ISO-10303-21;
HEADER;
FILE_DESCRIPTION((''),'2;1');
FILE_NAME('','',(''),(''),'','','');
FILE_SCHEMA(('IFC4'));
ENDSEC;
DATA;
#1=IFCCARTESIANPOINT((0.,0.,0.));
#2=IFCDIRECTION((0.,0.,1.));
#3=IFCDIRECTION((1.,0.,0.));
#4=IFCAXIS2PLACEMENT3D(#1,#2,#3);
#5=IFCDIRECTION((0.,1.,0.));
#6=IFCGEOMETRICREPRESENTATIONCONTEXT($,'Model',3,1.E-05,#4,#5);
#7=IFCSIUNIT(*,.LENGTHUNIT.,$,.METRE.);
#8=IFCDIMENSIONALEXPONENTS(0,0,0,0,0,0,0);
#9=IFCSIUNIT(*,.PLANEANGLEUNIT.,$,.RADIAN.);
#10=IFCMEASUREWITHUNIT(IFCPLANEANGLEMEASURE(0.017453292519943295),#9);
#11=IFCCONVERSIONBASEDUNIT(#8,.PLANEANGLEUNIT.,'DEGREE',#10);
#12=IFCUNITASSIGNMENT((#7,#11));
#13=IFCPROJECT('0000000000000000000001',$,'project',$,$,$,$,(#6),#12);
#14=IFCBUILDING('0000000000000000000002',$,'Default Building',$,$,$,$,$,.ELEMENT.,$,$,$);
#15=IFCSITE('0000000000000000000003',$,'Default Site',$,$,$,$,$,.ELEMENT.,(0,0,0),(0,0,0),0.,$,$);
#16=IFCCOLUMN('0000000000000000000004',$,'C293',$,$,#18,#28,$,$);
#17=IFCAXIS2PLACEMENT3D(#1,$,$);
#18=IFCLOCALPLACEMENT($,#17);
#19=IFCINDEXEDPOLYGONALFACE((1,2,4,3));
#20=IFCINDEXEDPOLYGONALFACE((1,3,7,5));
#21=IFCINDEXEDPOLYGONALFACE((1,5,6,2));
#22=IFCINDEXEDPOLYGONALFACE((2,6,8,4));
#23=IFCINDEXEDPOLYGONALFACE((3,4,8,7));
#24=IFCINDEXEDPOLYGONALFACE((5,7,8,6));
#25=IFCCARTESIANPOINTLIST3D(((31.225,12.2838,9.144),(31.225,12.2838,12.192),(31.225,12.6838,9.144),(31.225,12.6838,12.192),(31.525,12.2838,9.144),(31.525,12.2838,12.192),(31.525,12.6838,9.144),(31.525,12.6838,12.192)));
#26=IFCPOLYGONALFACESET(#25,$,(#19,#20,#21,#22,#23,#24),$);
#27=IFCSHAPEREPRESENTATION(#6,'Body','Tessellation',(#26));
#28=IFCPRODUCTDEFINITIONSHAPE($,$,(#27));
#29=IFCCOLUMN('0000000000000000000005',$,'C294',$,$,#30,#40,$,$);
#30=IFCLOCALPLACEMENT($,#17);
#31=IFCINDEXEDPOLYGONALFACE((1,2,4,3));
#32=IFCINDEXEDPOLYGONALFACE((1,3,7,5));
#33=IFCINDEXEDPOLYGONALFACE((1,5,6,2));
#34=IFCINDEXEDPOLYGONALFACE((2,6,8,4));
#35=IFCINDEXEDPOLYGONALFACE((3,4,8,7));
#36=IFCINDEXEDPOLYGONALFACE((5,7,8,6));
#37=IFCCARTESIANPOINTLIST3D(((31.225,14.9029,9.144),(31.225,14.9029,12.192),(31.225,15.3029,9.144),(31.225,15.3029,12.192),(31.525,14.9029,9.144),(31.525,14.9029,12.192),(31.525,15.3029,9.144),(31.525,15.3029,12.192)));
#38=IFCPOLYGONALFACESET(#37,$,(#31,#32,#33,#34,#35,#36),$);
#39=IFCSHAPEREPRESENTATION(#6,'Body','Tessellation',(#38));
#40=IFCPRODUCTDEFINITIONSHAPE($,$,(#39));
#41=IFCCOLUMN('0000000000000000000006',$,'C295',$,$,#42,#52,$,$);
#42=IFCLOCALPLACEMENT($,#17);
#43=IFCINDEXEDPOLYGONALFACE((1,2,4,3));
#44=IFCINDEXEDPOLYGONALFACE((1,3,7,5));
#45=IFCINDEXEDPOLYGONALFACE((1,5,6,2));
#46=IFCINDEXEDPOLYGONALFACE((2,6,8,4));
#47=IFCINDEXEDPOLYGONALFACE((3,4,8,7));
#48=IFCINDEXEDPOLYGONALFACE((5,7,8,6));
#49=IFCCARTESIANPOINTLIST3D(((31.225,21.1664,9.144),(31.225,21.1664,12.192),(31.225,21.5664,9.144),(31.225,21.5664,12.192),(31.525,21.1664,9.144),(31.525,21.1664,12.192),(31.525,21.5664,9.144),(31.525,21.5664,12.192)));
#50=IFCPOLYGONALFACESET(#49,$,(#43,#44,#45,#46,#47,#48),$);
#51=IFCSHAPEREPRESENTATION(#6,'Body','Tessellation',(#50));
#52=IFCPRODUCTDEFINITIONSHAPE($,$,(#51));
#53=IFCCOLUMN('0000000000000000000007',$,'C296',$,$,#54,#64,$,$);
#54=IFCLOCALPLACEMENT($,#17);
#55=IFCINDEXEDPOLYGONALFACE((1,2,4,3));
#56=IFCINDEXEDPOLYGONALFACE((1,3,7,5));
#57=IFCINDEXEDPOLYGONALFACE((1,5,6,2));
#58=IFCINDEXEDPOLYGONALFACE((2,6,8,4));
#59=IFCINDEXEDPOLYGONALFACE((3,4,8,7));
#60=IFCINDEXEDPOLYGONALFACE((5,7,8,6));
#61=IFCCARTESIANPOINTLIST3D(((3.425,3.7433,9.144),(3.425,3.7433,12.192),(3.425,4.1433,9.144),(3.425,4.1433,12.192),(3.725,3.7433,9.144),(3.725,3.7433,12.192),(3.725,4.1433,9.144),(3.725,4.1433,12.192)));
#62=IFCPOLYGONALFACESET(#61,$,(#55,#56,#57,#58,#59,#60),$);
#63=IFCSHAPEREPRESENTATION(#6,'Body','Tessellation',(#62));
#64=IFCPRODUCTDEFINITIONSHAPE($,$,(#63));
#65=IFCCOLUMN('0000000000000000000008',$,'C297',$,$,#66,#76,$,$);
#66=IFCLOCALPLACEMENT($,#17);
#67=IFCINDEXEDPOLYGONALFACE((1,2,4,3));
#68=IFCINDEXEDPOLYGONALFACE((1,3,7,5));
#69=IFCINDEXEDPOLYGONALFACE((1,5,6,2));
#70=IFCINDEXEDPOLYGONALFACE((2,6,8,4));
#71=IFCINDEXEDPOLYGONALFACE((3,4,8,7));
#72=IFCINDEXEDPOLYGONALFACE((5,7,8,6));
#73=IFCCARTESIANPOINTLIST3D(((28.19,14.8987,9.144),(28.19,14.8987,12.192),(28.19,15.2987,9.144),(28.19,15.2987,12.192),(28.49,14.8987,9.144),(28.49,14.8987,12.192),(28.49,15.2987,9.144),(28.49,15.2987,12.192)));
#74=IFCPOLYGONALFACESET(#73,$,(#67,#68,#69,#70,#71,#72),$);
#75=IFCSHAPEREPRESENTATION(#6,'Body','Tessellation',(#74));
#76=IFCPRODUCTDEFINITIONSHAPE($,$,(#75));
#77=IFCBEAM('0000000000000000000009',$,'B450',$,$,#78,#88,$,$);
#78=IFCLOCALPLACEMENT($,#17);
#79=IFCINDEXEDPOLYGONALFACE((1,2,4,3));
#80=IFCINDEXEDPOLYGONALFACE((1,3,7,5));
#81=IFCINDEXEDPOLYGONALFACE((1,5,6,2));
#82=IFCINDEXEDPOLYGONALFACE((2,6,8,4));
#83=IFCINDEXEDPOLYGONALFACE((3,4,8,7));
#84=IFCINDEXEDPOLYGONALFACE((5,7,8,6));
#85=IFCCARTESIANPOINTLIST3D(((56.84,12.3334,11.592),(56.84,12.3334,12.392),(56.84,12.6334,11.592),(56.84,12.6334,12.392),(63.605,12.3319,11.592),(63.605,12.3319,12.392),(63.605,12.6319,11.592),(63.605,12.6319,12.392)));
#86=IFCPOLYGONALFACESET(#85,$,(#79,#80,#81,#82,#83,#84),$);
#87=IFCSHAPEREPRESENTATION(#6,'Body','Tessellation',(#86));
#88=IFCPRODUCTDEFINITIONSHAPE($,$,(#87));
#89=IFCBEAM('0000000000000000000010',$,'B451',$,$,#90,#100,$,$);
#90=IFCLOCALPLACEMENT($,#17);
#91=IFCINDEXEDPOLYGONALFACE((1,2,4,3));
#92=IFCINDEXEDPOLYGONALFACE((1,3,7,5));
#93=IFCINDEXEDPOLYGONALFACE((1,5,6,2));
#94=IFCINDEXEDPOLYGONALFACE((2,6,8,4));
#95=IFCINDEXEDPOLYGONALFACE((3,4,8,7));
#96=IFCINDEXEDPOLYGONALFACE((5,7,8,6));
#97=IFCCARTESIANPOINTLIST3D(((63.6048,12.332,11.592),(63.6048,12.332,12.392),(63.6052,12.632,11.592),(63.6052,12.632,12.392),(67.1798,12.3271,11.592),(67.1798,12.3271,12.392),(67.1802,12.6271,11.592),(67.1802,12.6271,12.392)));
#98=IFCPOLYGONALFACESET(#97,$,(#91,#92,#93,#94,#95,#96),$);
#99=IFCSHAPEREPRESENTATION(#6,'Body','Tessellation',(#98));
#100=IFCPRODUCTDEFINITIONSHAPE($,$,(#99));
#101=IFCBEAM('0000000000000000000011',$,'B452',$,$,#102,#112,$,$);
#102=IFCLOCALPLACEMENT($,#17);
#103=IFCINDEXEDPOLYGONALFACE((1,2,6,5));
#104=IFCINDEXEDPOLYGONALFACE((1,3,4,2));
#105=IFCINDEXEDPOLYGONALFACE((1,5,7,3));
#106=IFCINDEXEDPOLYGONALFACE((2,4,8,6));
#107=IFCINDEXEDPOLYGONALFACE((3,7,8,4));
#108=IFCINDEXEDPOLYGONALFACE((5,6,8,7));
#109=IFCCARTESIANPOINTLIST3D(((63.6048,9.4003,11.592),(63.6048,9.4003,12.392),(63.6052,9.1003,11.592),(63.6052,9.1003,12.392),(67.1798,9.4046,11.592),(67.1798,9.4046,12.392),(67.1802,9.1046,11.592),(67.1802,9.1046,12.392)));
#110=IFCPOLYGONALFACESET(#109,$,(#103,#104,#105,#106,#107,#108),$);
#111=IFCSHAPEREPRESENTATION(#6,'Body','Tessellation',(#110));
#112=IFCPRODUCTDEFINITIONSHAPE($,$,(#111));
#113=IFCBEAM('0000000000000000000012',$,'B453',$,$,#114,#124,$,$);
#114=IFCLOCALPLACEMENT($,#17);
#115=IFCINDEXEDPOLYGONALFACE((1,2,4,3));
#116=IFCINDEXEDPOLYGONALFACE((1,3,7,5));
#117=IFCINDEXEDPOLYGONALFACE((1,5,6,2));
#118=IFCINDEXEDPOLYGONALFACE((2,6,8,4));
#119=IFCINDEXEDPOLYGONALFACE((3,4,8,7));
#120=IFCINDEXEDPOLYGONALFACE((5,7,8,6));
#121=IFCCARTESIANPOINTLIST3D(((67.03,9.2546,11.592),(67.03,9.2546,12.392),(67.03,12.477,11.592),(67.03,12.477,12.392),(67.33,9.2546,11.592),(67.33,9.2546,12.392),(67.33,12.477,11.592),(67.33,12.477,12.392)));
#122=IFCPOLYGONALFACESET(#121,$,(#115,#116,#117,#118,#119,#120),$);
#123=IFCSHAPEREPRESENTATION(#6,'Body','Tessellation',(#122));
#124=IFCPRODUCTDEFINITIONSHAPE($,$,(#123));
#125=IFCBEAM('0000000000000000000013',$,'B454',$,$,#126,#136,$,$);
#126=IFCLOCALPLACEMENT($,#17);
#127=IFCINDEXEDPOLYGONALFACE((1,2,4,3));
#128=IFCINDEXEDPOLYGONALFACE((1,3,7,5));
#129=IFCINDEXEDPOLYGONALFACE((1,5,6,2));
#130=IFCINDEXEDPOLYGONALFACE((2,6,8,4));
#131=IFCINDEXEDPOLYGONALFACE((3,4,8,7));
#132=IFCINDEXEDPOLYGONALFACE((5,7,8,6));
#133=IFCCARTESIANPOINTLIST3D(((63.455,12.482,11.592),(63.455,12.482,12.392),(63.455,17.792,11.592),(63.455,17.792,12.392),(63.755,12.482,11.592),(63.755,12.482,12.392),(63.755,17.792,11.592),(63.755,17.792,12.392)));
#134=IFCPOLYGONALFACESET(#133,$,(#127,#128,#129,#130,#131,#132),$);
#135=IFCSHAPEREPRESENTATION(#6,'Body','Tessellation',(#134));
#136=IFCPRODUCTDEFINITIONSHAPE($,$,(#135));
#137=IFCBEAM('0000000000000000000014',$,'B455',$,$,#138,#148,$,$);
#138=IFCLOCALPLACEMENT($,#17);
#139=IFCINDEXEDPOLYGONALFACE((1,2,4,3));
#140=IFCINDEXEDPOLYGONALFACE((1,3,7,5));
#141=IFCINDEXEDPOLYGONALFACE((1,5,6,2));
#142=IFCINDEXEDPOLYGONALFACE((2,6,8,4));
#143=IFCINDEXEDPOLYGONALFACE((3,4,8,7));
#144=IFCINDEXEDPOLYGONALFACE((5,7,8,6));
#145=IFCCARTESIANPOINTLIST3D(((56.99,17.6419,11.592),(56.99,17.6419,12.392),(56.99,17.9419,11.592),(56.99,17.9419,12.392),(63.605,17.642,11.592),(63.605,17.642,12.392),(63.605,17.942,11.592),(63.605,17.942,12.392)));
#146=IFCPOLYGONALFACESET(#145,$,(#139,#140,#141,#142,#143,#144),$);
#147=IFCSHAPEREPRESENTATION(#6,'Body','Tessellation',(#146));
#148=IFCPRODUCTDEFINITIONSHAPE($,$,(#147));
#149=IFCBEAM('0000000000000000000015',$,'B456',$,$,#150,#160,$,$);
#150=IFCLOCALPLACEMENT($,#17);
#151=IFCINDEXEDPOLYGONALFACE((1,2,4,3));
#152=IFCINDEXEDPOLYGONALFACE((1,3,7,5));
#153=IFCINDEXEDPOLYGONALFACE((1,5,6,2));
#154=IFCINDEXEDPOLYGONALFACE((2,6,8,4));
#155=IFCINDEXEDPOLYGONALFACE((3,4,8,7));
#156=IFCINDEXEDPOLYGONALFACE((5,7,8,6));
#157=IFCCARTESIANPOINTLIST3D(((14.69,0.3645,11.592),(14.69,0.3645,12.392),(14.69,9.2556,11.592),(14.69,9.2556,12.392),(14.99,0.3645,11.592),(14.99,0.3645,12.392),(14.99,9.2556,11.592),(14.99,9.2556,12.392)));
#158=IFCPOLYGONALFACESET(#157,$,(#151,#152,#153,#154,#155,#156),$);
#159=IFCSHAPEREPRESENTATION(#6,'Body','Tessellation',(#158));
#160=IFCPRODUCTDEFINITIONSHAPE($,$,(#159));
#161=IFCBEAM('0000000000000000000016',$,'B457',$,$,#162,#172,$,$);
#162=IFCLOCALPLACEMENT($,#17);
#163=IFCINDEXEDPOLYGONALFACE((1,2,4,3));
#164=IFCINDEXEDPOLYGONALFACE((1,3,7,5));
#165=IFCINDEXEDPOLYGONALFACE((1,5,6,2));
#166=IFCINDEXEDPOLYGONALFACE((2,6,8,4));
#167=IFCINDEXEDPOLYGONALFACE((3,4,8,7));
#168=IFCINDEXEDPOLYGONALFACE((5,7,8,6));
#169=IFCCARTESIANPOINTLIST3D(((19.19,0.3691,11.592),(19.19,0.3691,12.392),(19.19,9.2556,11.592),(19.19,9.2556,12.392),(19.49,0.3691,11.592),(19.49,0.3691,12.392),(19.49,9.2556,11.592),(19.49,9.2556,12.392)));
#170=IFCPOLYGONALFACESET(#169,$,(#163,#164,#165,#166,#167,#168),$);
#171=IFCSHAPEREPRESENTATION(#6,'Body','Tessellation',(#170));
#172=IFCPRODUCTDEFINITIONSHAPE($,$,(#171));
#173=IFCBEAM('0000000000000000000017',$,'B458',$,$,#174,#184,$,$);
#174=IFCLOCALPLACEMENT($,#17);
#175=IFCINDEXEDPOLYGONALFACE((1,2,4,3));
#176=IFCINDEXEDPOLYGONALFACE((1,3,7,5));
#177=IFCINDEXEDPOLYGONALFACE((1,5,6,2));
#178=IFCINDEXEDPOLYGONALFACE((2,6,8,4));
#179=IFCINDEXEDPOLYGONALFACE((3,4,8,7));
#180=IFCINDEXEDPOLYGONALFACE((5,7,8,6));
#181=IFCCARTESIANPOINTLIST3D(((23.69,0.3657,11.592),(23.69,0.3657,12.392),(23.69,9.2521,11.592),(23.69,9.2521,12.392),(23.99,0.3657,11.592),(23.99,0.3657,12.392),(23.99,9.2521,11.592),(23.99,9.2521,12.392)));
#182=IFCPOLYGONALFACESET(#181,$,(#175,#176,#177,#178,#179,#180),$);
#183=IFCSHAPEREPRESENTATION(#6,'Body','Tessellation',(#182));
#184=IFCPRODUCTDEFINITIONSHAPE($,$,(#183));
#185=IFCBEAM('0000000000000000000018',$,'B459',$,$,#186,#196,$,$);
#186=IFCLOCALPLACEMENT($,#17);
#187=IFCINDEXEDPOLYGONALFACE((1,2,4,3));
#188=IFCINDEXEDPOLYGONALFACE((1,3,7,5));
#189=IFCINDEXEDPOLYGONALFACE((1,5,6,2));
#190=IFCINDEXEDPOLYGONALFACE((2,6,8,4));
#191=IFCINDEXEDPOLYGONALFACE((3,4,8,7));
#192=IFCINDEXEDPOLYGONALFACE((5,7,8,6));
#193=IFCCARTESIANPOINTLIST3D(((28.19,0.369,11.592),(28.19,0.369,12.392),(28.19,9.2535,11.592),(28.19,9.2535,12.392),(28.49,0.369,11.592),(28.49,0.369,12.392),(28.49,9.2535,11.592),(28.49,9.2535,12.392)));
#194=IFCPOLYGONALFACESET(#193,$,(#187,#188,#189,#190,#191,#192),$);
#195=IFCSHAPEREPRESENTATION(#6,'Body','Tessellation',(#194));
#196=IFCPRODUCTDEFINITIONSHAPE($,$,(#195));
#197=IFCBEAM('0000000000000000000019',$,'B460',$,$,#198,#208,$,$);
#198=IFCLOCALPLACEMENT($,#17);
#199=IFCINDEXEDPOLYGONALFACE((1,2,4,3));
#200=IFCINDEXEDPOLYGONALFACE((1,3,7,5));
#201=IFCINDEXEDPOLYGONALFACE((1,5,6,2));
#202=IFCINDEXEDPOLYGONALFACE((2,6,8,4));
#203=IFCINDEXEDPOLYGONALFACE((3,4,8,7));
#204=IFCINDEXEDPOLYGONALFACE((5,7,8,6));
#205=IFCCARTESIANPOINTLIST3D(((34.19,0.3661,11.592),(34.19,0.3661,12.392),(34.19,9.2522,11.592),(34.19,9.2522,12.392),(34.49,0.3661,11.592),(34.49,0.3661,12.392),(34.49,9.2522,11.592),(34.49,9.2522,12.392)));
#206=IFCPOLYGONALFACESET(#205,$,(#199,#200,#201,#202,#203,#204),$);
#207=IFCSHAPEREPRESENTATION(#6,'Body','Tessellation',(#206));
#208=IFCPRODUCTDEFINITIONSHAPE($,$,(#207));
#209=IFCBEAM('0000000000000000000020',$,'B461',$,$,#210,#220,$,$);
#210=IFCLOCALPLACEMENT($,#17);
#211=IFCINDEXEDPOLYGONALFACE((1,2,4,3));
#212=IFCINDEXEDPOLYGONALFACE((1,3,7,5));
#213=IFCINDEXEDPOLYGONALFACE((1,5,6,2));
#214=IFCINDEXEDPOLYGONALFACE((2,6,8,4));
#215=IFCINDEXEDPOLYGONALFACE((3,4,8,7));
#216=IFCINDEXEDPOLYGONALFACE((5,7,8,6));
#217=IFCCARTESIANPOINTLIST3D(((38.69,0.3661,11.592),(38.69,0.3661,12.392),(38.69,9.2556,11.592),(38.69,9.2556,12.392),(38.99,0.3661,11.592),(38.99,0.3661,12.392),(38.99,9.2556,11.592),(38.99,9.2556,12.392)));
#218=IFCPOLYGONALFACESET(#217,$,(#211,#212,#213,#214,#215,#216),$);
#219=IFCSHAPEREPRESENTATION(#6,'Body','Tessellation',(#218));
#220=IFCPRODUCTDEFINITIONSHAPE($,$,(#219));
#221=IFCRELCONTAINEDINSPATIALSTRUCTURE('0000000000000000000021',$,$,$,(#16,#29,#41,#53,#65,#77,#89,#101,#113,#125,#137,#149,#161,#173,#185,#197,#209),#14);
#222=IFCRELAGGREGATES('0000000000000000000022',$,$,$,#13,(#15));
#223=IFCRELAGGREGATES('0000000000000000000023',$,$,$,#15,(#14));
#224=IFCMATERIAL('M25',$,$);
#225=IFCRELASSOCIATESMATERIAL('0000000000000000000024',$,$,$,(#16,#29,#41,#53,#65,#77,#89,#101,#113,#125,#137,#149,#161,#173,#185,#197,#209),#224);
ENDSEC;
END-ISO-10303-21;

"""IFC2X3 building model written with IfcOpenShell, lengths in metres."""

from ifc_helpers import new_model, entity, si_unit, converted_unit, direction, frame, frame_2d, origin_with_axes, place, context, project, spatial, rectangle, extrude, material, element, save


model = new_model("IFC2X3")

# Units and contexts
model_context = context("Model", 3, precision=1e-05, world=origin_with_axes(), true_north=direction((0.0, 1.0, 0.0)))
ifc_project = project(units=[si_unit("LENGTHUNIT", "METRE"), converted_unit("PLANEANGLEUNIT", "DEGREE", entity("IfcPlaneAngleMeasure", 0.017453292519943295), si_unit("PLANEANGLEUNIT", "RADIAN"), dimensions=[0, 0, 0, 0, 0, 0, 0])], contexts=[model_context])

# Site, building
site = spatial("IfcSite", under=ifc_project, Name="Default Site", CompositionType="ELEMENT", RefLatitude=(0, 0, 0), RefLongitude=(0, 0, 0), RefElevation=0.0)
building = spatial("IfcBuilding", under=site, Name="Default Building", CompositionType="ELEMENT")

# Columns
ifc_material = material(Name="M25")
placement = place(None, origin_with_axes())
element("IfcColumn", 1, at=placement, inside=building, material=ifc_material, Name="C293", context=model_context, shape_type="SweptSolid", body=[
    extrude(rectangle(XDim=0.3, YDim=0.4, at=frame_2d((0.0, 0.0), x_axis=(1.0, 0.0, 0.0))), frame((31.375, 12.4838, 9.144), z_axis=(0.0, 0.0, 1.0), x_axis=(1.0, 0.0, 0.0)), (0.0, 0.0, 1.0), 3.048),
])
element("IfcColumn", 2, at=placement, inside=building, material=ifc_material, Name="C294", context=model_context, shape_type="SweptSolid", body=[
    extrude(rectangle(XDim=0.3, YDim=0.4, at=frame_2d((0.0, 0.0), x_axis=(1.0, 0.0, 0.0))), frame((31.375, 15.1029, 9.144), z_axis=(0.0, 0.0, 1.0), x_axis=(1.0, 0.0, 0.0)), (0.0, 0.0, 1.0), 3.048),
])
element("IfcColumn", 3, at=placement, inside=building, material=ifc_material, Name="C295", context=model_context, shape_type="SweptSolid", body=[
    extrude(rectangle(XDim=0.3, YDim=0.4, at=frame_2d((0.0, 0.0), x_axis=(1.0, 0.0, 0.0))), frame((31.375, 21.3664, 9.144), z_axis=(0.0, 0.0, 1.0), x_axis=(1.0, 0.0, 0.0)), (0.0, 0.0, 1.0), 3.048),
])
element("IfcColumn", 4, at=placement, inside=building, material=ifc_material, Name="C296", context=model_context, shape_type="SweptSolid", body=[
    extrude(rectangle(XDim=0.3, YDim=0.4, at=frame_2d((0.0, 0.0), x_axis=(1.0, 0.0, 0.0))), frame((3.575, 3.9433, 9.144), z_axis=(0.0, 0.0, 1.0), x_axis=(1.0, 0.0, 0.0)), (0.0, 0.0, 1.0), 3.048),
])
element("IfcColumn", 5, at=placement, inside=building, material=ifc_material, Name="C297", context=model_context, shape_type="SweptSolid", body=[
    extrude(rectangle(XDim=0.3, YDim=0.4, at=frame_2d((0.0, 0.0), x_axis=(1.0, 0.0, 0.0))), frame((28.34, 15.0987, 9.144), z_axis=(0.0, 0.0, 1.0), x_axis=(1.0, 0.0, 0.0)), (0.0, 0.0, 1.0), 3.048),
])

# Beams
element("IfcBeam", 6, at=placement, inside=building, material=ifc_material, Name="B450", context=model_context, shape_type="SweptSolid", body=[
    extrude(rectangle(XDim=0.3, YDim=0.8, at=frame_2d((0.0, 0.0), x_axis=(0.0, 1.0, 0.0))), frame((56.84, 12.4834, 11.992), z_axis=(1.0, -0.000216, 0.0), x_axis=(0.0, 0.0, -1.0)), (0.0, 0.0, 1.0), 6.765),
])
element("IfcBeam", 7, at=placement, inside=building, material=ifc_material, Name="B451", context=model_context, shape_type="SweptSolid", body=[
    extrude(rectangle(XDim=0.3, YDim=0.8, at=frame_2d((0.0, 0.0), x_axis=(0.0, 1.0, 0.0))), frame((63.605, 12.482, 11.992), z_axis=(0.999999, -0.001379, 0.0), x_axis=(0.0, 0.0, -1.0)), (0.0, 0.0, 1.0), 3.575),
])
element("IfcBeam", 8, at=placement, inside=building, material=ifc_material, Name="B452", context=model_context, shape_type="SweptSolid", body=[
    extrude(rectangle(XDim=0.3, YDim=0.8, at=frame_2d((0.0, 0.0), x_axis=(0.0, 1.0, 0.0))), frame((63.605, 9.2503, 11.992), z_axis=(0.999999, 0.001188, 0.0), x_axis=(0.0, 0.0, -1.0)), (0.0, 0.0, 1.0), 3.575),
])
element("IfcBeam", 9, at=placement, inside=building, material=ifc_material, Name="B453", context=model_context, shape_type="SweptSolid", body=[
    extrude(rectangle(XDim=0.3, YDim=0.8, at=frame_2d((0.0, 0.0), x_axis=(0.0, 1.0, 0.0))), frame((67.18, 9.2546, 11.992), z_axis=(0.0, 1.0, 0.0), x_axis=(0.0, 0.0, -1.0)), (0.0, 0.0, 1.0), 3.2224),
])
element("IfcBeam", 10, at=placement, inside=building, material=ifc_material, Name="B454", context=model_context, shape_type="SweptSolid", body=[
    extrude(rectangle(XDim=0.3, YDim=0.8, at=frame_2d((0.0, 0.0), x_axis=(0.0, 1.0, 0.0))), frame((63.605, 12.482, 11.992), z_axis=(0.0, 1.0, 0.0), x_axis=(0.0, 0.0, -1.0)), (0.0, 0.0, 1.0), 5.3101),
])
element("IfcBeam", 11, at=placement, inside=building, material=ifc_material, Name="B455", context=model_context, shape_type="SweptSolid", body=[
    extrude(rectangle(XDim=0.3, YDim=0.8, at=frame_2d((0.0, 0.0), x_axis=(0.0, 1.0, 0.0))), frame((56.99, 17.7919, 11.992), z_axis=(1.0, 0.00002, 0.0), x_axis=(0.0, 0.0, -1.0)), (0.0, 0.0, 1.0), 6.615),
])
element("IfcBeam", 12, at=placement, inside=building, material=ifc_material, Name="B456", context=model_context, shape_type="SweptSolid", body=[
    extrude(rectangle(XDim=0.3, YDim=0.8, at=frame_2d((0.0, 0.0), x_axis=(0.0, 1.0, 0.0))), frame((14.84, 0.3645, 11.992), z_axis=(0.0, 1.0, 0.0), x_axis=(0.0, 0.0, -1.0)), (0.0, 0.0, 1.0), 8.891),
])
element("IfcBeam", 13, at=placement, inside=building, material=ifc_material, Name="B457", context=model_context, shape_type="SweptSolid", body=[
    extrude(rectangle(XDim=0.3, YDim=0.8, at=frame_2d((0.0, 0.0), x_axis=(0.0, 1.0, 0.0))), frame((19.34, 0.3691, 11.992), z_axis=(0.0, 1.0, 0.0), x_axis=(0.0, 0.0, -1.0)), (0.0, 0.0, 1.0), 8.8865),
])
element("IfcBeam", 14, at=placement, inside=building, material=ifc_material, Name="B458", context=model_context, shape_type="SweptSolid", body=[
    extrude(rectangle(XDim=0.3, YDim=0.8, at=frame_2d((0.0, 0.0), x_axis=(0.0, 1.0, 0.0))), frame((23.84, 0.3657, 11.992), z_axis=(0.0, 1.0, 0.0), x_axis=(0.0, 0.0, -1.0)), (0.0, 0.0, 1.0), 8.8864),
])
element("IfcBeam", 15, at=placement, inside=building, material=ifc_material, Name="B459", context=model_context, shape_type="SweptSolid", body=[
    extrude(rectangle(XDim=0.3, YDim=0.8, at=frame_2d((0.0, 0.0), x_axis=(0.0, 1.0, 0.0))), frame((28.34, 0.369, 11.992), z_axis=(0.0, 1.0, 0.0), x_axis=(0.0, 0.0, -1.0)), (0.0, 0.0, 1.0), 8.8845),
])
element("IfcBeam", 16, at=placement, inside=building, material=ifc_material, Name="B460", context=model_context, shape_type="SweptSolid", body=[
    extrude(rectangle(XDim=0.3, YDim=0.8, at=frame_2d((0.0, 0.0), x_axis=(0.0, 1.0, 0.0))), frame((34.34, 0.3661, 11.992), z_axis=(0.0, 1.0, 0.0), x_axis=(0.0, 0.0, -1.0)), (0.0, 0.0, 1.0), 8.8861),
])
element("IfcBeam", 17, at=placement, inside=building, material=ifc_material, Name="B461", context=model_context, shape_type="SweptSolid", body=[
    extrude(rectangle(XDim=0.3, YDim=0.8, at=frame_2d((0.0, 0.0), x_axis=(0.0, 1.0, 0.0))), frame((38.84, 0.3661, 11.992), z_axis=(0.0, 1.0, 0.0), x_axis=(0.0, 0.0, -1.0)), (0.0, 0.0, 1.0), 8.8895),
])

save(model, "model.ifc")
